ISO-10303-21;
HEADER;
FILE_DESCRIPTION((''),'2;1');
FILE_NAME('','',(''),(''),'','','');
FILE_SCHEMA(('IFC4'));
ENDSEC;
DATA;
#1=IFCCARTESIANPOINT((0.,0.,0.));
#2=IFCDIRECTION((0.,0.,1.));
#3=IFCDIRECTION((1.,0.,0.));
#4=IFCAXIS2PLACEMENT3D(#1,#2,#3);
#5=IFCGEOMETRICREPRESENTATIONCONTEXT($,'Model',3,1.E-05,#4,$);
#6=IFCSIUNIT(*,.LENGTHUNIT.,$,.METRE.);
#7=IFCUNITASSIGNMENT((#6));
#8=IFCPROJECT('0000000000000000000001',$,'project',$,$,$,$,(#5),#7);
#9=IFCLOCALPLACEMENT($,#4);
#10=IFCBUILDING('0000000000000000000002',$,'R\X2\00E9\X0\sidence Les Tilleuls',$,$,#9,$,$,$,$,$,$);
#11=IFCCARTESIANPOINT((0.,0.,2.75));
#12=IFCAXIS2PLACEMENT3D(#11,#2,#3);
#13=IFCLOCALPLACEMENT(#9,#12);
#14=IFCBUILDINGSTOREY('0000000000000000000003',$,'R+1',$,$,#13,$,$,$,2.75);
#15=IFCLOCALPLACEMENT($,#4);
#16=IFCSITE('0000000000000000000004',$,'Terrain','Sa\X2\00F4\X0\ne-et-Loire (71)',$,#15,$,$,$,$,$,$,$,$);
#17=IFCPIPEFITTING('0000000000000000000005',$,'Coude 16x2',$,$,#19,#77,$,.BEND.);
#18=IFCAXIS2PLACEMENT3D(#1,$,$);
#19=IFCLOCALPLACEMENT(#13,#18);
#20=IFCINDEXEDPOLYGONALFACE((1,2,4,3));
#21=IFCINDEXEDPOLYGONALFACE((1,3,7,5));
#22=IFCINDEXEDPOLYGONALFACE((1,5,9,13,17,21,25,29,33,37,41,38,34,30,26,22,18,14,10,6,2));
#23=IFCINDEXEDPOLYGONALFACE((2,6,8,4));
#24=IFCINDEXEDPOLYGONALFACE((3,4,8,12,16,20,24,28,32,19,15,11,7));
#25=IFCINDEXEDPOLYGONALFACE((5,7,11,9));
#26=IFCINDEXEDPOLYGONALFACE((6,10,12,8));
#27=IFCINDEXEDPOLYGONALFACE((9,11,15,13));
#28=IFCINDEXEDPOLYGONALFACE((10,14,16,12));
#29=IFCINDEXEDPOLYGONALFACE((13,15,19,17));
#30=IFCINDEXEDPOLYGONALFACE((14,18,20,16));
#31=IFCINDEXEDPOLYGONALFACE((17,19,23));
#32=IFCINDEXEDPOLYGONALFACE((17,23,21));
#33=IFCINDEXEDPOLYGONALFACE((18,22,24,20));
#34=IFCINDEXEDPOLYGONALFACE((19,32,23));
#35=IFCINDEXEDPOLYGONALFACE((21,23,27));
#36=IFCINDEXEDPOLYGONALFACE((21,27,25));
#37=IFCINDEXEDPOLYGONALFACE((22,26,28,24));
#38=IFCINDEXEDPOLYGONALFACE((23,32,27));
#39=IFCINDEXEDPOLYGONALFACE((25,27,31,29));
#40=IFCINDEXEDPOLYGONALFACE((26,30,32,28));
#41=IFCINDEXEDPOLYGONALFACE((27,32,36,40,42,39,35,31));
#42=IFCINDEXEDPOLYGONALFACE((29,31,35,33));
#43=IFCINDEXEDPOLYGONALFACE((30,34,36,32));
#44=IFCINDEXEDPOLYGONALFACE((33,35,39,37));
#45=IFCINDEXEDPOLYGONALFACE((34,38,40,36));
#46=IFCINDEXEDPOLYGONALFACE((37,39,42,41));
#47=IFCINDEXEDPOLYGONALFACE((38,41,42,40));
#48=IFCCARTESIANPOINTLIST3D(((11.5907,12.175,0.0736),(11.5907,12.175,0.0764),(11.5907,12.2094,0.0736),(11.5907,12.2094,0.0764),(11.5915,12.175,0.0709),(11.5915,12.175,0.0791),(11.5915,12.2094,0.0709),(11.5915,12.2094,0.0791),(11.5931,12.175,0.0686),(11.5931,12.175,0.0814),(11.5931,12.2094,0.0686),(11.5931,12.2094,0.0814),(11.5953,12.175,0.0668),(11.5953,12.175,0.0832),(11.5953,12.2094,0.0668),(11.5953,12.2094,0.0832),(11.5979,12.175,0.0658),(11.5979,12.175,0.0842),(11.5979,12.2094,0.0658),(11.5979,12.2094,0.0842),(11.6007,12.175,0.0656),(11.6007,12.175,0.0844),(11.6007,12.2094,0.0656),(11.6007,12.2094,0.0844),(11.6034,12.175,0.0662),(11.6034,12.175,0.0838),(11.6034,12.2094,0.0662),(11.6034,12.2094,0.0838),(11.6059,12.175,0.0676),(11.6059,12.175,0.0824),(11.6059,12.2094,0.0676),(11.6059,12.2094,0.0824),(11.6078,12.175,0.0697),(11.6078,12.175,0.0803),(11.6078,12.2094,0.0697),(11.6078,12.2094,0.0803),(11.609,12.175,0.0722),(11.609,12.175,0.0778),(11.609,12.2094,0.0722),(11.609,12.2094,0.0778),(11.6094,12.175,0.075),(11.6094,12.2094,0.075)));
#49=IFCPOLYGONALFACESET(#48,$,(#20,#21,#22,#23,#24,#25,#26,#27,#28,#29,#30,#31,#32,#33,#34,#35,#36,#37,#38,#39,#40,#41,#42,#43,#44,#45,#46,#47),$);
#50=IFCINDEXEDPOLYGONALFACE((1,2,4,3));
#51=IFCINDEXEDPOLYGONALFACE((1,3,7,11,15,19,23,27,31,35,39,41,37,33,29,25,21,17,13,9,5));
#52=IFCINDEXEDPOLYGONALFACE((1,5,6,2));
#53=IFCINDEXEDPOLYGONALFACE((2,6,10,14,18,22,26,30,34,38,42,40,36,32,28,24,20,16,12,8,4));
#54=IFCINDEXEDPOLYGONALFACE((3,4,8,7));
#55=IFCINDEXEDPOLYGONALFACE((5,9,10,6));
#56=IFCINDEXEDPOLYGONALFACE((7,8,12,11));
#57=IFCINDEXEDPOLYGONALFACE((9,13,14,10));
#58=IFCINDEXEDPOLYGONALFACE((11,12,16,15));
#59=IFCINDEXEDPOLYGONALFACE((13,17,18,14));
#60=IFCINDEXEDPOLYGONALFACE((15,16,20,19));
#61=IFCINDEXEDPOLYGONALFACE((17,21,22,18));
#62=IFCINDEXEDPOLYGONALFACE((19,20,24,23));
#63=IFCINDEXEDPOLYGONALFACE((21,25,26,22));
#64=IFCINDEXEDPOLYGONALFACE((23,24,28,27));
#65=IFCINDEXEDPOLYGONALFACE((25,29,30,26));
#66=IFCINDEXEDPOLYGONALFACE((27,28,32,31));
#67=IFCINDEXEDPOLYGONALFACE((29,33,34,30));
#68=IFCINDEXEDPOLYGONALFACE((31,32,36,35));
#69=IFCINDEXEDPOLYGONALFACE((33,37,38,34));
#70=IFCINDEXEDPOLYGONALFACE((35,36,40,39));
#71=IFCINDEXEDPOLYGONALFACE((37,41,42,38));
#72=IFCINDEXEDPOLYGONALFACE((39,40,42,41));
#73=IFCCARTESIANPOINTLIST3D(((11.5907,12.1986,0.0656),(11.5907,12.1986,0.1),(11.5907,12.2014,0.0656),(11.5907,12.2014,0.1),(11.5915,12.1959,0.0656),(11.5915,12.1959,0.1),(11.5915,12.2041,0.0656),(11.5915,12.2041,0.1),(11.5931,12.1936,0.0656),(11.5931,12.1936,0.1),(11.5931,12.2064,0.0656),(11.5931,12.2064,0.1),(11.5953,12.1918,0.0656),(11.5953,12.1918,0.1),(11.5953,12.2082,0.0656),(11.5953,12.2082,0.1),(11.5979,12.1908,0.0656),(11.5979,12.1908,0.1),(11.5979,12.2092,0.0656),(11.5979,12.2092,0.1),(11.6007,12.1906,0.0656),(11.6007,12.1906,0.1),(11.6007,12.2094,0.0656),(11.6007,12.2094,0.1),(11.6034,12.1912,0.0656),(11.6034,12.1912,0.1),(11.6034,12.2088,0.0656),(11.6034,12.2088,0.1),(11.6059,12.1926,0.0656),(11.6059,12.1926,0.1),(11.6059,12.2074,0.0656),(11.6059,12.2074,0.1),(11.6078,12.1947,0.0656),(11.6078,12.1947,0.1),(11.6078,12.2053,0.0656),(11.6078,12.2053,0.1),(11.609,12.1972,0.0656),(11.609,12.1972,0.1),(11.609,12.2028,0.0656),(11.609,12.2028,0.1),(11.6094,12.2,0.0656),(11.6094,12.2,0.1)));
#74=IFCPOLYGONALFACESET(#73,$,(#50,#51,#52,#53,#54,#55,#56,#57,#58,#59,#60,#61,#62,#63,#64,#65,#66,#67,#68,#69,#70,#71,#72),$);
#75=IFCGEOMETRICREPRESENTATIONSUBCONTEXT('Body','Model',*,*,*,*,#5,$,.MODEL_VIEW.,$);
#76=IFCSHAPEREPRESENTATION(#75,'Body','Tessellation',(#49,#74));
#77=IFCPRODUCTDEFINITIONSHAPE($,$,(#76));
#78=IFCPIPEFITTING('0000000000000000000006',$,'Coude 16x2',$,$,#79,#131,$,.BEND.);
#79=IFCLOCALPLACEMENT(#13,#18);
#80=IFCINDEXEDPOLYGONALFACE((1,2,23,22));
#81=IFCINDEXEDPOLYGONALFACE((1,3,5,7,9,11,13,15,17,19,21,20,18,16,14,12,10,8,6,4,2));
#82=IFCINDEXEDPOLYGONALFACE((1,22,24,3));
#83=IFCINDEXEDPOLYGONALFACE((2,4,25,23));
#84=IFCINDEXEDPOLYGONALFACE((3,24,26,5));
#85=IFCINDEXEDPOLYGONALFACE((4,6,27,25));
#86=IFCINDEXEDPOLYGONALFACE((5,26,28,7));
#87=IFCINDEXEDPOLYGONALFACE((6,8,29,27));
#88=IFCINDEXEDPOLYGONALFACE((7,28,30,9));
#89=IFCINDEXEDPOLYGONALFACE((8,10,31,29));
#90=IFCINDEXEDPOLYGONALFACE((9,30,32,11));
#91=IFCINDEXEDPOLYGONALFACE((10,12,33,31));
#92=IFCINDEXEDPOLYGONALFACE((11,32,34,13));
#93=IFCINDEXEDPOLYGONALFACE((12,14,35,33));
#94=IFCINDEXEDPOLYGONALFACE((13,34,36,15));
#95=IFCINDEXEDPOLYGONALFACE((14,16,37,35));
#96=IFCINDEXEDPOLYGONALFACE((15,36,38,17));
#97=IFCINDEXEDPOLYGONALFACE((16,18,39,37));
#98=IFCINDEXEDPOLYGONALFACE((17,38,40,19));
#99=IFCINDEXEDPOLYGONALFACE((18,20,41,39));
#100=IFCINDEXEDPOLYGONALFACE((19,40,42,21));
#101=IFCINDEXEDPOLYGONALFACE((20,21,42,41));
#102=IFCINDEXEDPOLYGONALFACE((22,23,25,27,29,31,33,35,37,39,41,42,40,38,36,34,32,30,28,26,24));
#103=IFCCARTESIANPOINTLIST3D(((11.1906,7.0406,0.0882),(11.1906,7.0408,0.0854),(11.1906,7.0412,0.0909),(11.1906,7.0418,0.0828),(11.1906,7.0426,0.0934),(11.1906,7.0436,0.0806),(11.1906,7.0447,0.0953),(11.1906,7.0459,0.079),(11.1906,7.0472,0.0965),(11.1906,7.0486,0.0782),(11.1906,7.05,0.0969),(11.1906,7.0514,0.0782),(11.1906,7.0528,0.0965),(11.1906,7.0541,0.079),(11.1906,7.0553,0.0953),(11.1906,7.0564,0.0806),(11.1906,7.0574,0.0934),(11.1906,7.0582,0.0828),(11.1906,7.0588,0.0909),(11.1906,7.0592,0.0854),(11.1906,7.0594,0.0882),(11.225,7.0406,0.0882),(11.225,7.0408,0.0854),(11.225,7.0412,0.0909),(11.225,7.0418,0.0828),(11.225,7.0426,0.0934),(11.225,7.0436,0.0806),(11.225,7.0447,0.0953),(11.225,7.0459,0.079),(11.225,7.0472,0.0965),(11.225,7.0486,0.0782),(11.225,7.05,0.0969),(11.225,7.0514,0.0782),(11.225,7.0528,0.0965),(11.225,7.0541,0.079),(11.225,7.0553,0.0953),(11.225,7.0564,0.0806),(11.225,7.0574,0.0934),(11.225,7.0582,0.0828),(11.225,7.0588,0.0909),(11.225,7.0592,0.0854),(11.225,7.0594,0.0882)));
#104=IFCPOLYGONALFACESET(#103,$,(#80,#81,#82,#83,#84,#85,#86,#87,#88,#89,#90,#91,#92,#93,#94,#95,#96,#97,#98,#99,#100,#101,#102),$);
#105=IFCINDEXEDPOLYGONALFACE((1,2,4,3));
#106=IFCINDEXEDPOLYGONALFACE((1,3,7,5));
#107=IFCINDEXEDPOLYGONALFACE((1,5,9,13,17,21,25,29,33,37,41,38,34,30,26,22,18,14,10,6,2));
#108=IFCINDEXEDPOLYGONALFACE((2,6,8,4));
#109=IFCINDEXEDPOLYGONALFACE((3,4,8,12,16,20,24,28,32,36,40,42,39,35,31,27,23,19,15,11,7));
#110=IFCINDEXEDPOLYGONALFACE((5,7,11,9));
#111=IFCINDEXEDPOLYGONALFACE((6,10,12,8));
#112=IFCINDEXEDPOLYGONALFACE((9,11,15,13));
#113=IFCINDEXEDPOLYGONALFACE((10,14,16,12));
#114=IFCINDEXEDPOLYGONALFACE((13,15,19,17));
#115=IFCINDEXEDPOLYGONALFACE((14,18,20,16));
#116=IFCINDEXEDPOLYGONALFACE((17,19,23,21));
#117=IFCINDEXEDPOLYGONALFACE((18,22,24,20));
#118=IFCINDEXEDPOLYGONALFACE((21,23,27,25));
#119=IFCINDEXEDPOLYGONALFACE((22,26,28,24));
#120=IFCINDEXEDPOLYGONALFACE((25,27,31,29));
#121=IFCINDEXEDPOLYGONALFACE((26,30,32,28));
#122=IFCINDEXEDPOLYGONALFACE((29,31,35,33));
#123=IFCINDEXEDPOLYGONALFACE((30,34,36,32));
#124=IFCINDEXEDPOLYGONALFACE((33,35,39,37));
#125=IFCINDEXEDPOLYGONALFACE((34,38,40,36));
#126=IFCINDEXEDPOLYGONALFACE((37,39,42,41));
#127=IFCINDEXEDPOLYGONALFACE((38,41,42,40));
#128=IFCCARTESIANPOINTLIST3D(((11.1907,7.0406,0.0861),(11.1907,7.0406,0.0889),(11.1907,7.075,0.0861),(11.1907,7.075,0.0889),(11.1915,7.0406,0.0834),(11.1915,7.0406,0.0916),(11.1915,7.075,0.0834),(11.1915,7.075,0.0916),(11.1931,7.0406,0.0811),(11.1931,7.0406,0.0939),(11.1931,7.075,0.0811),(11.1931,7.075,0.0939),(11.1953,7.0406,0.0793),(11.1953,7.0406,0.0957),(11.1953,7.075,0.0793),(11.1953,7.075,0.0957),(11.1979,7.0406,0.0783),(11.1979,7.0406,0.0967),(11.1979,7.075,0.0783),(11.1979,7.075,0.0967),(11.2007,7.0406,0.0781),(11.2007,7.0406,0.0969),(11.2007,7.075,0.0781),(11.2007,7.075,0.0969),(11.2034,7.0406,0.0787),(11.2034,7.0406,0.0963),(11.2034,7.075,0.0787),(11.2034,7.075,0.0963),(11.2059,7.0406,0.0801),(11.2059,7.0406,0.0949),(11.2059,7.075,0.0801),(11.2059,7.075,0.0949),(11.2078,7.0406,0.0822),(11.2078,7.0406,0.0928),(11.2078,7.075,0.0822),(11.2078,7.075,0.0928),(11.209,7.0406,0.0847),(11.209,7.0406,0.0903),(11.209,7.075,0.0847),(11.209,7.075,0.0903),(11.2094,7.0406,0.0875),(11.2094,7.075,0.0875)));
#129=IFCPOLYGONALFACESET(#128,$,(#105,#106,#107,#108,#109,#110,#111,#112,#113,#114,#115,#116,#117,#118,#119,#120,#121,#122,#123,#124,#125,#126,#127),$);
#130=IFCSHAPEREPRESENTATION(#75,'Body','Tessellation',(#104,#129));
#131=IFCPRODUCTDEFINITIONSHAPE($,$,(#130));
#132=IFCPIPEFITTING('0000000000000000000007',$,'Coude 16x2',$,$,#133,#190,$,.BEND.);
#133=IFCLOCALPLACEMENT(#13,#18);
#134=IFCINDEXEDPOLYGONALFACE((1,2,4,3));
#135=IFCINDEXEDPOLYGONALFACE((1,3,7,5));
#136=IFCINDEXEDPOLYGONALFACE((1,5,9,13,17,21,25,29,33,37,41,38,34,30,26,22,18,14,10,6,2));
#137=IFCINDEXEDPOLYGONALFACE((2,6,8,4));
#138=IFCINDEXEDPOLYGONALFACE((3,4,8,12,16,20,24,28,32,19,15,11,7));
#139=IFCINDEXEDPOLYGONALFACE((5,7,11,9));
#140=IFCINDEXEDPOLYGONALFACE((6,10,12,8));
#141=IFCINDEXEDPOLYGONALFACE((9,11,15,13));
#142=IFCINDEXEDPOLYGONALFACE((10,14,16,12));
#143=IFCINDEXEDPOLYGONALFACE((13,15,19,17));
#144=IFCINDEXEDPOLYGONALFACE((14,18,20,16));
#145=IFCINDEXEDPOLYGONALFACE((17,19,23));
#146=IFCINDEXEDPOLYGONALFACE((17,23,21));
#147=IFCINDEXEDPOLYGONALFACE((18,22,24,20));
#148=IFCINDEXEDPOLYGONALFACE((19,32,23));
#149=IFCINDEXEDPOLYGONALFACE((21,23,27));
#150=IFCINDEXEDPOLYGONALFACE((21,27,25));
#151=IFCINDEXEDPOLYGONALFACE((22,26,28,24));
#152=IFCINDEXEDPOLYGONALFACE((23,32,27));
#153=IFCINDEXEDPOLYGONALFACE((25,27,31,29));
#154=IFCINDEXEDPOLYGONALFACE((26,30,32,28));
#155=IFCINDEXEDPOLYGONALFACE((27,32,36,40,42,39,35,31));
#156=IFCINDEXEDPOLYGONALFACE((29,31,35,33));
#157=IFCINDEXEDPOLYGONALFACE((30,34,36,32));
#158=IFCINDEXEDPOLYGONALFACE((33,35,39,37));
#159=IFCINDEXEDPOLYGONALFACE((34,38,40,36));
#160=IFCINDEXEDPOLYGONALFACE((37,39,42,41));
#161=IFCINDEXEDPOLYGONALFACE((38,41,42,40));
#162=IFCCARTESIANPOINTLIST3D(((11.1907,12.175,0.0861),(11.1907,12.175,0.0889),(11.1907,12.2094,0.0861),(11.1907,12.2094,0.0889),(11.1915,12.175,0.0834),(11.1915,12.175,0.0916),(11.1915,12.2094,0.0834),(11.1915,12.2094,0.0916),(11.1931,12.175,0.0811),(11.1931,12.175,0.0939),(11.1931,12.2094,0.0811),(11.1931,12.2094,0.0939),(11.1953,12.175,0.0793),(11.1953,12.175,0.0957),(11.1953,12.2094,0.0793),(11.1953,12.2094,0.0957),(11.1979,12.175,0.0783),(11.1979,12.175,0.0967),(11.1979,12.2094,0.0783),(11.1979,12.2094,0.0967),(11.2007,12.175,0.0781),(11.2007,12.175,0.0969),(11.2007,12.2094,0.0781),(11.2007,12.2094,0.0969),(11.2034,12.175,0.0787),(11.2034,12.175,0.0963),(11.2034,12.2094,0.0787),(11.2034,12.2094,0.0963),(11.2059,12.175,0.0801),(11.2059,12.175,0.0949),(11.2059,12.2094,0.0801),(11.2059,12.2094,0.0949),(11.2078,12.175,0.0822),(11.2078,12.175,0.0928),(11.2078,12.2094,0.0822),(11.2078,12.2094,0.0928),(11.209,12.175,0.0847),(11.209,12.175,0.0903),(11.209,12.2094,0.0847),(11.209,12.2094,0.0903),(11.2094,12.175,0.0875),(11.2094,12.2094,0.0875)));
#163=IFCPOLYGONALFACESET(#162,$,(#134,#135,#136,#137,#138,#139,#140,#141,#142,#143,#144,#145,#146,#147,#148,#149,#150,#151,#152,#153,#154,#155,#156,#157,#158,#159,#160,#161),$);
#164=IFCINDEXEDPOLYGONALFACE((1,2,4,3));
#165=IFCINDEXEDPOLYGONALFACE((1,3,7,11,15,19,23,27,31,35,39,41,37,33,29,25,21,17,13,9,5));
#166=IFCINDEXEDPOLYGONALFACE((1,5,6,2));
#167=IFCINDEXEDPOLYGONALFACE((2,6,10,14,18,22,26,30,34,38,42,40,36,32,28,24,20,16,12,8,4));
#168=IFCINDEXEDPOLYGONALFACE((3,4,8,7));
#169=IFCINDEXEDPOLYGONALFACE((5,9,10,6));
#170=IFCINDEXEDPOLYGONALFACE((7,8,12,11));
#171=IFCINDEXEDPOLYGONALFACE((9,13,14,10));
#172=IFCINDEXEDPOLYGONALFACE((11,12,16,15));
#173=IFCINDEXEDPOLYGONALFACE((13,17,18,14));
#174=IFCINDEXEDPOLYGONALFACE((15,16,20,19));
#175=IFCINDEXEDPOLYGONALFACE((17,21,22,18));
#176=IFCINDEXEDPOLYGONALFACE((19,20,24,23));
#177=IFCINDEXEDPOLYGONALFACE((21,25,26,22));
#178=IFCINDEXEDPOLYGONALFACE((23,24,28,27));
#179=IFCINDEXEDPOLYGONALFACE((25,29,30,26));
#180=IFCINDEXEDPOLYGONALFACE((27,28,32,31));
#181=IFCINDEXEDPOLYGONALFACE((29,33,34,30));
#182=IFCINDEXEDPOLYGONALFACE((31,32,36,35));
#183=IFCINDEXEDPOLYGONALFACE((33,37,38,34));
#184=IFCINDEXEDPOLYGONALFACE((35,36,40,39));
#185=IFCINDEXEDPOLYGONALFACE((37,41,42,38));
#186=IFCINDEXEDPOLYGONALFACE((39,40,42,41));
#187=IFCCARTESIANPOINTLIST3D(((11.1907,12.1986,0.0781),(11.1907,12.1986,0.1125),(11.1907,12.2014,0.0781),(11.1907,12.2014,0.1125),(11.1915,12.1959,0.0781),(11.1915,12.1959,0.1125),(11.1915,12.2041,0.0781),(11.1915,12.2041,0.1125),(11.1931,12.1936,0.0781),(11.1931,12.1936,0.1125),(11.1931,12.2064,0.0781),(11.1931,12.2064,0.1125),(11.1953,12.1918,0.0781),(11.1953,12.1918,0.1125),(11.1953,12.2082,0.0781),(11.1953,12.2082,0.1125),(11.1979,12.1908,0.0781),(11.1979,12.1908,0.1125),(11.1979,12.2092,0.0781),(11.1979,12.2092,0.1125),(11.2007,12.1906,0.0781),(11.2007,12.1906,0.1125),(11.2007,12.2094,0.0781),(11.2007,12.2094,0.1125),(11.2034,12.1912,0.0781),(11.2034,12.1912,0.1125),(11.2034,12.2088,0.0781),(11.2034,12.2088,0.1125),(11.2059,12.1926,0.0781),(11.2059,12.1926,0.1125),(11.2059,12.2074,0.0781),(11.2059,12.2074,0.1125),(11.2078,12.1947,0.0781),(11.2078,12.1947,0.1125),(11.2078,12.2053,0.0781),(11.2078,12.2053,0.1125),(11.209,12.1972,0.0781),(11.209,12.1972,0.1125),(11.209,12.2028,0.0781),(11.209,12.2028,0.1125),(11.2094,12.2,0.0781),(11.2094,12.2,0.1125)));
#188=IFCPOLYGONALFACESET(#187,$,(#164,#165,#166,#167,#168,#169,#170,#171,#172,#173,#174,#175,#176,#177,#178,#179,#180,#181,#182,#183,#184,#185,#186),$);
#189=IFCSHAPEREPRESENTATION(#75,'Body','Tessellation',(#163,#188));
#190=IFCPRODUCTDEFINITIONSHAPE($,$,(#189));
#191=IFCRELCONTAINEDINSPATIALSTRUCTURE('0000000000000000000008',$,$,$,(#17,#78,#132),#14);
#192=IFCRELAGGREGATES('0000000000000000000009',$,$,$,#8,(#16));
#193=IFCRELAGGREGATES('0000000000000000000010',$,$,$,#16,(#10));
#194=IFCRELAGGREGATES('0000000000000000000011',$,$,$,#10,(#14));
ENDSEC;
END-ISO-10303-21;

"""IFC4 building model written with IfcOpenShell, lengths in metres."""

from ifc_helpers import new_model, si_unit, frame, origin_with_axes, place, context, subcontext, project, spatial, circle, extrude, element, save


model = new_model("IFC4")

# Units and contexts
model_context = context("Model", 3, precision=1e-05, world=origin_with_axes())
body_context = subcontext(model_context, "Body", "Model", "MODEL_VIEW")
ifc_project = project(units=[si_unit("LENGTHUNIT", "METRE")], contexts=[model_context])

# Site, building, storey
site_placement = place(None, origin_with_axes())
site = spatial("IfcSite", under=ifc_project, at=site_placement, Name="Terrain", Description="Saône-et-Loire (71)")
building_placement = place(None, origin_with_axes())
building = spatial("IfcBuilding", under=site, at=building_placement, Name="Résidence Les Tilleuls")
storey_placement = place(building_placement, frame((0.0, 0.0, 2.75), z_axis=(0.0, 0.0, 1.0), x_axis=(1.0, 0.0, 0.0)))
storey = spatial("IfcBuildingStorey", under=building, at=storey_placement, Name="R+1", Elevation=2.75)

# Pipe fittings
pipe_fitting_1_placement = place(storey_placement, frame((11.6, 12.2, 0.075), z_axis=(0.0, 0.0, 1.0), x_axis=(1.0, 0.0, 0.0)))
element("IfcPipeFitting", 1, at=pipe_fitting_1_placement, inside=storey, Name="Coude 16x2", PredefinedType="BEND", context=body_context, shape_type="SweptSolid", body=[
    extrude(circle(Radius=0.0094), frame((0.0, 0.0094, 0.0), z_axis=(0.0, -1.0, 0.0), x_axis=(1.0, 0.0, 0.0)), (0.0, 0.0, 1.0), 0.0344),
    extrude(circle(Radius=0.0094), frame((0.0, 0.0, -0.0094), z_axis=(0.0, 0.0, 1.0), x_axis=(1.0, 0.0, 0.0)), (0.0, 0.0, 1.0), 0.0344),
])
pipe_fitting_2_placement = place(storey_placement, frame((11.2, 7.05, 0.0875), z_axis=(0.0, 0.0, 1.0), x_axis=(1.0, 0.0, 0.0)))
element("IfcPipeFitting", 2, at=pipe_fitting_2_placement, inside=storey, Name="Coude 16x2", PredefinedType="BEND", context=body_context, shape_type="SweptSolid", body=[
    extrude(circle(Radius=0.0094), frame((-0.0094, 0.0, 0.0), z_axis=(1.0, 0.0, 0.0), x_axis=(0.0, 0.0, 1.0)), (0.0, 0.0, 1.0), 0.0344),
    extrude(circle(Radius=0.0094), frame((0.0, -0.0094, 0.0), z_axis=(0.0, 1.0, 0.0), x_axis=(1.0, 0.0, 0.0)), (0.0, 0.0, 1.0), 0.0344),
])
pipe_fitting_3_placement = place(storey_placement, frame((11.2, 12.2, 0.0875), z_axis=(0.0, 0.0, 1.0), x_axis=(1.0, 0.0, 0.0)))
element("IfcPipeFitting", 3, at=pipe_fitting_3_placement, inside=storey, Name="Coude 16x2", PredefinedType="BEND", context=body_context, shape_type="SweptSolid", body=[
    extrude(circle(Radius=0.0094), frame((0.0, 0.0094, 0.0), z_axis=(0.0, -1.0, 0.0), x_axis=(1.0, 0.0, 0.0)), (0.0, 0.0, 1.0), 0.0344),
    extrude(circle(Radius=0.0094), frame((0.0, 0.0, -0.0094), z_axis=(0.0, 0.0, 1.0), x_axis=(1.0, 0.0, 0.0)), (0.0, 0.0, 1.0), 0.0344),
])

save(model, "model.ifc")
